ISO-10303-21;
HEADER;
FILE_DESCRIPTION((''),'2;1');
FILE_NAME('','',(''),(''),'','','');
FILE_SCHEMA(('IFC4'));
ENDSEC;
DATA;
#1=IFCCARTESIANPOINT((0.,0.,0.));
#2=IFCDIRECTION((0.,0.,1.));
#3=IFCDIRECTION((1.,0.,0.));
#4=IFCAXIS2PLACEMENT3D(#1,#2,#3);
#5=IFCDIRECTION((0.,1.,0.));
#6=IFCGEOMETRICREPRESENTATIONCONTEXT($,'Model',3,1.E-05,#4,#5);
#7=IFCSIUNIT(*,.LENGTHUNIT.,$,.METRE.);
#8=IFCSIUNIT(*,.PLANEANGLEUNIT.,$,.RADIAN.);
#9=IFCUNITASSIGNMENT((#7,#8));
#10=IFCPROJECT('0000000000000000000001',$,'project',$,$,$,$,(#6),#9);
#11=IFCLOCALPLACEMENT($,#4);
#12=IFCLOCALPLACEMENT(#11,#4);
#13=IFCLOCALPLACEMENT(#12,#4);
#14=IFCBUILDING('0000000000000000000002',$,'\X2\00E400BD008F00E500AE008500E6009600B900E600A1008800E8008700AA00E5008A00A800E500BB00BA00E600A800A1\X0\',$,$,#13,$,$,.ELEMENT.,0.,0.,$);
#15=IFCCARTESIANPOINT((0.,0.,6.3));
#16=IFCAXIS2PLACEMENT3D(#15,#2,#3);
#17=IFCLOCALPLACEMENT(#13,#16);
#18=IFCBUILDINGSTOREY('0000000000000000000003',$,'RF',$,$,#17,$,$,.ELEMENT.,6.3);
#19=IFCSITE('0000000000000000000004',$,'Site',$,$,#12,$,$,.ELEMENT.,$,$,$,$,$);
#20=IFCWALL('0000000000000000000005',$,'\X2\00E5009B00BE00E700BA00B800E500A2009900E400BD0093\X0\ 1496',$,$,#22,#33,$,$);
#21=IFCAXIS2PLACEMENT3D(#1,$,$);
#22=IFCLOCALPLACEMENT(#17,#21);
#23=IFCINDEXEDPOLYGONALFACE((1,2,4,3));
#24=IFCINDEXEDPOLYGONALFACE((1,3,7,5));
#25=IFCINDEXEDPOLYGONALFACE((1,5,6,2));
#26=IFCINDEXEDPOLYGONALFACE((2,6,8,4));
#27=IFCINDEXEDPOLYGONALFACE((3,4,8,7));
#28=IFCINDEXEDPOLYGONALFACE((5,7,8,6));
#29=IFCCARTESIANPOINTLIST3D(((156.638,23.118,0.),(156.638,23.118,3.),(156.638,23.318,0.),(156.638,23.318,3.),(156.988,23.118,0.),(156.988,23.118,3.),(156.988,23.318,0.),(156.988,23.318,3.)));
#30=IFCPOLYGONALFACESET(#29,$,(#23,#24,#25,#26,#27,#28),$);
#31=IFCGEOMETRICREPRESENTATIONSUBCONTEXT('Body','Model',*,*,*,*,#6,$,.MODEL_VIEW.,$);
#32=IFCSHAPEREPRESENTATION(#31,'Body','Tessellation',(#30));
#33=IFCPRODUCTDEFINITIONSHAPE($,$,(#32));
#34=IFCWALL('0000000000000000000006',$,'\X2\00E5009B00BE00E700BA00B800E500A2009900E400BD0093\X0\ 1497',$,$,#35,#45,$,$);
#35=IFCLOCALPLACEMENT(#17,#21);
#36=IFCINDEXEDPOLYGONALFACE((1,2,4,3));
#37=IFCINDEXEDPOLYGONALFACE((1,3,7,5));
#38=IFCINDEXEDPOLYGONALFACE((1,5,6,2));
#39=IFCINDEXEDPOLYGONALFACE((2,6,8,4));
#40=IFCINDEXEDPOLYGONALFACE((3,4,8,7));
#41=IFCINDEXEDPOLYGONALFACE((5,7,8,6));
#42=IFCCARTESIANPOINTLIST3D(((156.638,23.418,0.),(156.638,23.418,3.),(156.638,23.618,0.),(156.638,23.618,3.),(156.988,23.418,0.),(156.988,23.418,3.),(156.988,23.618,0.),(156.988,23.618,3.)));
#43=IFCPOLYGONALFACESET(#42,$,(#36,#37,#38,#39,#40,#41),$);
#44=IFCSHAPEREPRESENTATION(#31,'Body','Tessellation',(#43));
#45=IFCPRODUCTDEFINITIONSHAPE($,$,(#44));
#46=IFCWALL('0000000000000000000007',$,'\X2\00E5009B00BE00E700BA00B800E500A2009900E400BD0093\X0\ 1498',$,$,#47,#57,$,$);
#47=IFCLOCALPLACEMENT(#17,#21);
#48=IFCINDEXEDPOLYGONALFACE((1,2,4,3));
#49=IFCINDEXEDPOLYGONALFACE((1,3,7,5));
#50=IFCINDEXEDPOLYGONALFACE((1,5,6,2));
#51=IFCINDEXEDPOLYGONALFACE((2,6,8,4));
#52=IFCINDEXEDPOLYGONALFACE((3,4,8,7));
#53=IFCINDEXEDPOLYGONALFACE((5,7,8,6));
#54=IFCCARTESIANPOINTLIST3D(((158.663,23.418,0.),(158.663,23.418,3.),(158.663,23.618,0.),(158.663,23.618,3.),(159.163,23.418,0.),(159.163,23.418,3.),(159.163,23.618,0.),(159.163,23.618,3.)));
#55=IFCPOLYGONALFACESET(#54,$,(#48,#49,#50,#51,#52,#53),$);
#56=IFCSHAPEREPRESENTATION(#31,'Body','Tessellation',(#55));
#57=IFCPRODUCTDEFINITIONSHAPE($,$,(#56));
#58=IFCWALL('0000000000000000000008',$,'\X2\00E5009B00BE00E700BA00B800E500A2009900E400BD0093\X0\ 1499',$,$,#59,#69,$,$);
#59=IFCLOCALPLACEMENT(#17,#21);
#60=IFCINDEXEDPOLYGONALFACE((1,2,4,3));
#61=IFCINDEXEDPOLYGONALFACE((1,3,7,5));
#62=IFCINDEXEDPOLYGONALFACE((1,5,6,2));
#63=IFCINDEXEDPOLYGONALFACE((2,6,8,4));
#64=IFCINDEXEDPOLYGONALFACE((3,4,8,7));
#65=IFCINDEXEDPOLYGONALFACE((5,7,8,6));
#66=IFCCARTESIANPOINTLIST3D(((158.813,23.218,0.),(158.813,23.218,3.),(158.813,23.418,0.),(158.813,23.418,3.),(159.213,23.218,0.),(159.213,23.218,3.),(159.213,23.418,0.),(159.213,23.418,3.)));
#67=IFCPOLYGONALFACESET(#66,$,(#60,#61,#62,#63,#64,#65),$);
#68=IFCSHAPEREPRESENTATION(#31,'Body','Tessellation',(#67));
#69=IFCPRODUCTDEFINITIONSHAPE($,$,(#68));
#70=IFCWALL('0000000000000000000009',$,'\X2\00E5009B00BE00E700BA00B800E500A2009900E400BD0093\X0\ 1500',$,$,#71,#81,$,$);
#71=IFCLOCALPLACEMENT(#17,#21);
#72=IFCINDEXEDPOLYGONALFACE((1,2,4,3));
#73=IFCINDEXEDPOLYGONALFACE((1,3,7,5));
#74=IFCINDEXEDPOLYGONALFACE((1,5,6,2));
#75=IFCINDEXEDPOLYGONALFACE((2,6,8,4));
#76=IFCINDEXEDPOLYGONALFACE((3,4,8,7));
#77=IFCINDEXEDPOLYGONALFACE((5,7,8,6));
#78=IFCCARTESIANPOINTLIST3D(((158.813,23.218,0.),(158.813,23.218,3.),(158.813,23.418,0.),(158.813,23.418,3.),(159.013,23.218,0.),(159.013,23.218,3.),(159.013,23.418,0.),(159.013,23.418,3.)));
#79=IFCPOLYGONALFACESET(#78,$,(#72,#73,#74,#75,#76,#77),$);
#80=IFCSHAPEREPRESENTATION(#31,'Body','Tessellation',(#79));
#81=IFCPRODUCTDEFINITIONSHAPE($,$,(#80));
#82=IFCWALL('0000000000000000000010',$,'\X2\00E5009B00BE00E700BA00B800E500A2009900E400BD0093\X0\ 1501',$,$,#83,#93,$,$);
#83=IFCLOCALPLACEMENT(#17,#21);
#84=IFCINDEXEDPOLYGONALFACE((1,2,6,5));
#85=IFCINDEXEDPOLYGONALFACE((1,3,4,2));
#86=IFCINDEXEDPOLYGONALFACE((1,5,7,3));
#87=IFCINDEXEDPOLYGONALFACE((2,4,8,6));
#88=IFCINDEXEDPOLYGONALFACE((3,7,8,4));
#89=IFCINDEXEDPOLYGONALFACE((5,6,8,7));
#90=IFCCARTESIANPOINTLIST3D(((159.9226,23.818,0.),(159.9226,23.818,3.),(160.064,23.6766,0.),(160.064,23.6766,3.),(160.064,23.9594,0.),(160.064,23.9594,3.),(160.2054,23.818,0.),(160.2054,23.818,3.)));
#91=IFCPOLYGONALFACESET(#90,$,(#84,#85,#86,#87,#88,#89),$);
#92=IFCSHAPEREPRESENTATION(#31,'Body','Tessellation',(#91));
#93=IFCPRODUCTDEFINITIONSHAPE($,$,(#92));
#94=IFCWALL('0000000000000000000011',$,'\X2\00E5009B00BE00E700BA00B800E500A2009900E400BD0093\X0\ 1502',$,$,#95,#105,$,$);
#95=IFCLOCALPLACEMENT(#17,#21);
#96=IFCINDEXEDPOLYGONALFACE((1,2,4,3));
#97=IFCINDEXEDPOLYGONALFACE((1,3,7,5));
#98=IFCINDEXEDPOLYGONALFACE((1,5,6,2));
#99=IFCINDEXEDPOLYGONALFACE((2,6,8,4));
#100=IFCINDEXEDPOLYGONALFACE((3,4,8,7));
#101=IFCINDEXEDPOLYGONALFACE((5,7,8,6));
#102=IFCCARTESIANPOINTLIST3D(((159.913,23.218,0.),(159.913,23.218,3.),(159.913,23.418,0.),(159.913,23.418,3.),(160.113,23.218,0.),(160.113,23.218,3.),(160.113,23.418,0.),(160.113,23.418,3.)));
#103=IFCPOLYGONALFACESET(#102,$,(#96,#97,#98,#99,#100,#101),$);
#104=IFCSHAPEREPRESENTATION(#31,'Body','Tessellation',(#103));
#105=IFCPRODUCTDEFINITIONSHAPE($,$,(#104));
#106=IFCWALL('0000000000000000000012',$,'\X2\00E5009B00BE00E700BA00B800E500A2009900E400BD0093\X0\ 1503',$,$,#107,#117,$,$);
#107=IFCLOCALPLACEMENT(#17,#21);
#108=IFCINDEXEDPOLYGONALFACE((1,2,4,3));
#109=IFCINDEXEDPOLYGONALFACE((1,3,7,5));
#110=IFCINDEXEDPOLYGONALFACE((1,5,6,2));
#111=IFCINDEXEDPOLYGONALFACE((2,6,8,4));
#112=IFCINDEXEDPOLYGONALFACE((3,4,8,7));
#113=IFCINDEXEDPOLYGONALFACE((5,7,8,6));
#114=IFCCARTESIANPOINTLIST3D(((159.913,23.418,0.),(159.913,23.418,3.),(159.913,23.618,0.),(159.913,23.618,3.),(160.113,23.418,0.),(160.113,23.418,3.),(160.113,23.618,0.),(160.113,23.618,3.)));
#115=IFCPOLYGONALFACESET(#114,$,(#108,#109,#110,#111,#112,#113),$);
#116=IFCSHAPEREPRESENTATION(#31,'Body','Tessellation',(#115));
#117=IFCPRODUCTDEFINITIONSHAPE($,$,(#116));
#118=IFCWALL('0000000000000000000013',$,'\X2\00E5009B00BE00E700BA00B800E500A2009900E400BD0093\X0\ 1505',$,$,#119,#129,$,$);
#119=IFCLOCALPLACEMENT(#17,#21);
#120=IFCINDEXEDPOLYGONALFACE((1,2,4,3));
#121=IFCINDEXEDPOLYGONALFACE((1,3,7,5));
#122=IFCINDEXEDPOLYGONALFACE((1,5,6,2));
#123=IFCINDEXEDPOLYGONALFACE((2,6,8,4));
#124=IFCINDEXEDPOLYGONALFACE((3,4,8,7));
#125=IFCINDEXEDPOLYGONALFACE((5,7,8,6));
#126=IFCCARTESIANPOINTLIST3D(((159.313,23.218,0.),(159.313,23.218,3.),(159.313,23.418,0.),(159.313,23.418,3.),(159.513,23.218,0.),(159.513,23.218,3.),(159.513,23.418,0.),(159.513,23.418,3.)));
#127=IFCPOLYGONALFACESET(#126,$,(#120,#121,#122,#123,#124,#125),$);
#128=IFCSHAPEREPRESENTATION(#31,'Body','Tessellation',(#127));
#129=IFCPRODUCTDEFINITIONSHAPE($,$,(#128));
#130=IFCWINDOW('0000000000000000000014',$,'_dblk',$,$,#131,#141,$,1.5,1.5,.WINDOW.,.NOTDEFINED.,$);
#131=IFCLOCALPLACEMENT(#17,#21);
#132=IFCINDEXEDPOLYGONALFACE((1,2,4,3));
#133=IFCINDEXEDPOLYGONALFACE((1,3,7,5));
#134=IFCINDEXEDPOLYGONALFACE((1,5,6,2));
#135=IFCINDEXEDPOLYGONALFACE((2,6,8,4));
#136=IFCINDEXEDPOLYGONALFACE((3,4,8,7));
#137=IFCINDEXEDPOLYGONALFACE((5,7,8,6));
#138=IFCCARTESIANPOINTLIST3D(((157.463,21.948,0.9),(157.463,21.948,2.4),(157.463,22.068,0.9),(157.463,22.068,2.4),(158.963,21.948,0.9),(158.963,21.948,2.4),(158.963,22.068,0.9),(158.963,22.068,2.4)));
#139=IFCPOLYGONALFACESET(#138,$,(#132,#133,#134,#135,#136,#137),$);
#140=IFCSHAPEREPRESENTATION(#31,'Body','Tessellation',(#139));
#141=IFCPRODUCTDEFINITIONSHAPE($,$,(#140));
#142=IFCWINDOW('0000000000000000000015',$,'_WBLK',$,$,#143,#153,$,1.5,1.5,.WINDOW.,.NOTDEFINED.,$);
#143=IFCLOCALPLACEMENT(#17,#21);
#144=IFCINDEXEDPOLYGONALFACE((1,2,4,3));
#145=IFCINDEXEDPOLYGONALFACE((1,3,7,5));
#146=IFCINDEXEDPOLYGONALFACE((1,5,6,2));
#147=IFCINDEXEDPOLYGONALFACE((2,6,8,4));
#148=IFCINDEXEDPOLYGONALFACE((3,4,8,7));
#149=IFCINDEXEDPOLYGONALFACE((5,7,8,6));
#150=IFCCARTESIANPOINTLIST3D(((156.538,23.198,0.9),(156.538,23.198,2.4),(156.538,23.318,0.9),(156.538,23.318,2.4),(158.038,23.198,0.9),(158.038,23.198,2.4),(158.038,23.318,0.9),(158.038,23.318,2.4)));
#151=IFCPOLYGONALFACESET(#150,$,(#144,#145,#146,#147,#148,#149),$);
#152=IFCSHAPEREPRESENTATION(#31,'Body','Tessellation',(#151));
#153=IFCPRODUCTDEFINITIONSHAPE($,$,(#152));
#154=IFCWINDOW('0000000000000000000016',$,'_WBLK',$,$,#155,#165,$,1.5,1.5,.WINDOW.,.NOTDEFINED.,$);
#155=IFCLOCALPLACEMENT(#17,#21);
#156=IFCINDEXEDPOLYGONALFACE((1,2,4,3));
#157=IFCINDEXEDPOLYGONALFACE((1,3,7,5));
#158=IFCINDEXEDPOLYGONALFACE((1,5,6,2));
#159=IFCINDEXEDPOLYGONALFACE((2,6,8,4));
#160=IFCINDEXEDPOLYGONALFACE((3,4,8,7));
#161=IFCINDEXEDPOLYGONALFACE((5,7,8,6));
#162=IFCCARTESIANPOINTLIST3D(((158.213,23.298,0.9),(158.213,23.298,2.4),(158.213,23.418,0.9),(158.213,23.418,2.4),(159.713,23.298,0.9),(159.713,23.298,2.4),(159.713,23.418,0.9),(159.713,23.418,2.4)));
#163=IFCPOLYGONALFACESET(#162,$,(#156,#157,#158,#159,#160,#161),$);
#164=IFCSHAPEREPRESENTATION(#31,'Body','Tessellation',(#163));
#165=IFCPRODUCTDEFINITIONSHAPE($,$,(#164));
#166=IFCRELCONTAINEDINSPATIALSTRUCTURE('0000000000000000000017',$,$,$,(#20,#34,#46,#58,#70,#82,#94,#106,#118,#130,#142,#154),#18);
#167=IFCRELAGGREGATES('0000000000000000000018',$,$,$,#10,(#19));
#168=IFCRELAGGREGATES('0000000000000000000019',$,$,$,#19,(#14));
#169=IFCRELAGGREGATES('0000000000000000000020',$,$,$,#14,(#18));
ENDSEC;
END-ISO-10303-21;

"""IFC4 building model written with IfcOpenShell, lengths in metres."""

from ifc_helpers import new_model, si_unit, direction, frame, frame_2d, origin_with_axes, place, context, subcontext, project, spatial, rectangle, extrude, element, save


model = new_model("IFC4")

# Units and contexts
model_context = context("Model", 3, precision=1e-05, world=origin_with_axes(), true_north=direction((0.0, 1.0, 0.0)))
body_context = subcontext(model_context, "Body", "Model", "MODEL_VIEW")
ifc_project = project(units=[si_unit("LENGTHUNIT", "METRE"), si_unit("PLANEANGLEUNIT", "RADIAN")], contexts=[model_context])

# Site, building, storey
placement = place(None, origin_with_axes())
site_placement = place(placement, origin_with_axes())
site = spatial("IfcSite", under=ifc_project, at=site_placement, Name="Site", CompositionType="ELEMENT")
building_placement = place(site_placement, origin_with_axes())
building = spatial("IfcBuilding", under=site, at=building_placement, Name="ä½\u008få®\u0085æ\u0096¹æ¡\u0088è\u0087ªå\u008a¨å»ºæ¨¡", CompositionType="ELEMENT", ElevationOfRefHeight=0.0, ElevationOfTerrain=0.0)
storey_placement = place(building_placement, frame((0.0, 0.0, 6.3), z_axis=(0.0, 0.0, 1.0), x_axis=(1.0, 0.0, 0.0)))
storey = spatial("IfcBuildingStorey", under=building, at=storey_placement, Name="RF", CompositionType="ELEMENT", Elevation=6.3)

# Walls
for number, where, z_axis, x_axis, name in (
    (1, (156.813, 23.218, 0.0), (0.0, 0.0, 1.0), (1.0, 0.0, 0.0), "å\u009b¾çº¸å¢\u0099ä½\u0093 1496"),
    (2, (156.813, 23.518, 0.0), (0.0, 0.0, 1.0), (1.0, 0.0, 0.0), "å\u009b¾çº¸å¢\u0099ä½\u0093 1497"),
):
    element("IfcWall", number, at=place(storey_placement, frame(where, z_axis=z_axis, x_axis=x_axis)), inside=storey, Name=name, context=body_context, shape_type="SweptSolid", body=[
        extrude(rectangle(XDim=0.35, YDim=0.2, at=frame_2d((0.0, 0.0), x_axis=(1.0, 0.0, 0.0))), frame((0.0, 0.0, 0.0), z_axis=(0.0, 0.0, 1.0)), (0.0, 0.0, 1.0), 3.0),
    ])
wall_1_placement = place(storey_placement, frame((158.913, 23.518, 0.0), z_axis=(0.0, 0.0, 1.0), x_axis=(1.0, 0.0, 0.0)))
element("IfcWall", 3, at=wall_1_placement, inside=storey, Name="å\u009b¾çº¸å¢\u0099ä½\u0093 1498", context=body_context, shape_type="SweptSolid", body=[
    extrude(rectangle(XDim=0.5, YDim=0.2, at=frame_2d((0.0, 0.0), x_axis=(1.0, 0.0, 0.0))), frame((0.0, 0.0, 0.0), z_axis=(0.0, 0.0, 1.0)), (0.0, 0.0, 1.0), 3.0),
])
wall_2_placement = place(storey_placement, frame((159.013, 23.318, 0.0), z_axis=(0.0, 0.0, 1.0), x_axis=(1.0, 0.0, 0.0)))
element("IfcWall", 4, at=wall_2_placement, inside=storey, Name="å\u009b¾çº¸å¢\u0099ä½\u0093 1499", context=body_context, shape_type="SweptSolid", body=[
    extrude(rectangle(XDim=0.4, YDim=0.2, at=frame_2d((0.0, 0.0), x_axis=(1.0, 0.0, 0.0))), frame((0.0, 0.0, 0.0), z_axis=(0.0, 0.0, 1.0)), (0.0, 0.0, 1.0), 3.0),
])
for number, where, z_axis, x_axis, name in (
    (5, (158.913, 23.318, 0.0), (0.0, 0.0, 1.0), (0.0, 1.0, 0.0), "å\u009b¾çº¸å¢\u0099ä½\u0093 1500"),
    (6, (160.064, 23.818, 0.0), (0.0, 0.0, 1.0), (-0.707107, -0.707107, 0.0), "å\u009b¾çº¸å¢\u0099ä½\u0093 1501"),
    (7, (160.013, 23.318, 0.0), (0.0, 0.0, 1.0), (1.0, 0.0, 0.0), "å\u009b¾çº¸å¢\u0099ä½\u0093 1502"),
    (8, (160.013, 23.518, 0.0), (0.0, 0.0, 1.0), (1.0, 0.0, 0.0), "å\u009b¾çº¸å¢\u0099ä½\u0093 1503"),
    (9, (159.413, 23.318, 0.0), (0.0, 0.0, 1.0), (0.0, 1.0, 0.0), "å\u009b¾çº¸å¢\u0099ä½\u0093 1505"),
):
    element("IfcWall", number, at=place(storey_placement, frame(where, z_axis=z_axis, x_axis=x_axis)), inside=storey, Name=name, context=body_context, shape_type="SweptSolid", body=[
        extrude(rectangle(XDim=0.2, YDim=0.2, at=frame_2d((0.0, 0.0), x_axis=(1.0, 0.0, 0.0))), frame((0.0, 0.0, 0.0), z_axis=(0.0, 0.0, 1.0)), (0.0, 0.0, 1.0), 3.0),
    ])

# Windows
for number, where, z_axis, x_axis, name in (
    (10, (158.213, 22.008, 0.9), (0.0, 0.0, 1.0), (1.0, 0.0, 0.0), "_dblk"),
    (11, (157.288, 23.258, 0.9), (0.0, 0.0, 1.0), (1.0, 0.0, 0.0), "_WBLK"),
    (12, (158.963, 23.358, 0.9), (0.0, 0.0, 1.0), (1.0, 0.0, 0.0), "_WBLK"),
):
    element("IfcWindow", number, at=place(storey_placement, frame(where, z_axis=z_axis, x_axis=x_axis)), inside=storey, Name=name, OverallHeight=1.5, OverallWidth=1.5, PartitioningType="NOTDEFINED", PredefinedType="WINDOW", context=body_context, shape_type="SweptSolid", body=[
        extrude(rectangle(XDim=1.5, YDim=0.12, at=frame_2d((0.0, 0.0), x_axis=(1.0, 0.0, 0.0))), frame((0.0, 0.0, 0.0), z_axis=(0.0, 0.0, 1.0)), (0.0, 0.0, 1.0), 1.5),
    ])

save(model, "model.ifc")
